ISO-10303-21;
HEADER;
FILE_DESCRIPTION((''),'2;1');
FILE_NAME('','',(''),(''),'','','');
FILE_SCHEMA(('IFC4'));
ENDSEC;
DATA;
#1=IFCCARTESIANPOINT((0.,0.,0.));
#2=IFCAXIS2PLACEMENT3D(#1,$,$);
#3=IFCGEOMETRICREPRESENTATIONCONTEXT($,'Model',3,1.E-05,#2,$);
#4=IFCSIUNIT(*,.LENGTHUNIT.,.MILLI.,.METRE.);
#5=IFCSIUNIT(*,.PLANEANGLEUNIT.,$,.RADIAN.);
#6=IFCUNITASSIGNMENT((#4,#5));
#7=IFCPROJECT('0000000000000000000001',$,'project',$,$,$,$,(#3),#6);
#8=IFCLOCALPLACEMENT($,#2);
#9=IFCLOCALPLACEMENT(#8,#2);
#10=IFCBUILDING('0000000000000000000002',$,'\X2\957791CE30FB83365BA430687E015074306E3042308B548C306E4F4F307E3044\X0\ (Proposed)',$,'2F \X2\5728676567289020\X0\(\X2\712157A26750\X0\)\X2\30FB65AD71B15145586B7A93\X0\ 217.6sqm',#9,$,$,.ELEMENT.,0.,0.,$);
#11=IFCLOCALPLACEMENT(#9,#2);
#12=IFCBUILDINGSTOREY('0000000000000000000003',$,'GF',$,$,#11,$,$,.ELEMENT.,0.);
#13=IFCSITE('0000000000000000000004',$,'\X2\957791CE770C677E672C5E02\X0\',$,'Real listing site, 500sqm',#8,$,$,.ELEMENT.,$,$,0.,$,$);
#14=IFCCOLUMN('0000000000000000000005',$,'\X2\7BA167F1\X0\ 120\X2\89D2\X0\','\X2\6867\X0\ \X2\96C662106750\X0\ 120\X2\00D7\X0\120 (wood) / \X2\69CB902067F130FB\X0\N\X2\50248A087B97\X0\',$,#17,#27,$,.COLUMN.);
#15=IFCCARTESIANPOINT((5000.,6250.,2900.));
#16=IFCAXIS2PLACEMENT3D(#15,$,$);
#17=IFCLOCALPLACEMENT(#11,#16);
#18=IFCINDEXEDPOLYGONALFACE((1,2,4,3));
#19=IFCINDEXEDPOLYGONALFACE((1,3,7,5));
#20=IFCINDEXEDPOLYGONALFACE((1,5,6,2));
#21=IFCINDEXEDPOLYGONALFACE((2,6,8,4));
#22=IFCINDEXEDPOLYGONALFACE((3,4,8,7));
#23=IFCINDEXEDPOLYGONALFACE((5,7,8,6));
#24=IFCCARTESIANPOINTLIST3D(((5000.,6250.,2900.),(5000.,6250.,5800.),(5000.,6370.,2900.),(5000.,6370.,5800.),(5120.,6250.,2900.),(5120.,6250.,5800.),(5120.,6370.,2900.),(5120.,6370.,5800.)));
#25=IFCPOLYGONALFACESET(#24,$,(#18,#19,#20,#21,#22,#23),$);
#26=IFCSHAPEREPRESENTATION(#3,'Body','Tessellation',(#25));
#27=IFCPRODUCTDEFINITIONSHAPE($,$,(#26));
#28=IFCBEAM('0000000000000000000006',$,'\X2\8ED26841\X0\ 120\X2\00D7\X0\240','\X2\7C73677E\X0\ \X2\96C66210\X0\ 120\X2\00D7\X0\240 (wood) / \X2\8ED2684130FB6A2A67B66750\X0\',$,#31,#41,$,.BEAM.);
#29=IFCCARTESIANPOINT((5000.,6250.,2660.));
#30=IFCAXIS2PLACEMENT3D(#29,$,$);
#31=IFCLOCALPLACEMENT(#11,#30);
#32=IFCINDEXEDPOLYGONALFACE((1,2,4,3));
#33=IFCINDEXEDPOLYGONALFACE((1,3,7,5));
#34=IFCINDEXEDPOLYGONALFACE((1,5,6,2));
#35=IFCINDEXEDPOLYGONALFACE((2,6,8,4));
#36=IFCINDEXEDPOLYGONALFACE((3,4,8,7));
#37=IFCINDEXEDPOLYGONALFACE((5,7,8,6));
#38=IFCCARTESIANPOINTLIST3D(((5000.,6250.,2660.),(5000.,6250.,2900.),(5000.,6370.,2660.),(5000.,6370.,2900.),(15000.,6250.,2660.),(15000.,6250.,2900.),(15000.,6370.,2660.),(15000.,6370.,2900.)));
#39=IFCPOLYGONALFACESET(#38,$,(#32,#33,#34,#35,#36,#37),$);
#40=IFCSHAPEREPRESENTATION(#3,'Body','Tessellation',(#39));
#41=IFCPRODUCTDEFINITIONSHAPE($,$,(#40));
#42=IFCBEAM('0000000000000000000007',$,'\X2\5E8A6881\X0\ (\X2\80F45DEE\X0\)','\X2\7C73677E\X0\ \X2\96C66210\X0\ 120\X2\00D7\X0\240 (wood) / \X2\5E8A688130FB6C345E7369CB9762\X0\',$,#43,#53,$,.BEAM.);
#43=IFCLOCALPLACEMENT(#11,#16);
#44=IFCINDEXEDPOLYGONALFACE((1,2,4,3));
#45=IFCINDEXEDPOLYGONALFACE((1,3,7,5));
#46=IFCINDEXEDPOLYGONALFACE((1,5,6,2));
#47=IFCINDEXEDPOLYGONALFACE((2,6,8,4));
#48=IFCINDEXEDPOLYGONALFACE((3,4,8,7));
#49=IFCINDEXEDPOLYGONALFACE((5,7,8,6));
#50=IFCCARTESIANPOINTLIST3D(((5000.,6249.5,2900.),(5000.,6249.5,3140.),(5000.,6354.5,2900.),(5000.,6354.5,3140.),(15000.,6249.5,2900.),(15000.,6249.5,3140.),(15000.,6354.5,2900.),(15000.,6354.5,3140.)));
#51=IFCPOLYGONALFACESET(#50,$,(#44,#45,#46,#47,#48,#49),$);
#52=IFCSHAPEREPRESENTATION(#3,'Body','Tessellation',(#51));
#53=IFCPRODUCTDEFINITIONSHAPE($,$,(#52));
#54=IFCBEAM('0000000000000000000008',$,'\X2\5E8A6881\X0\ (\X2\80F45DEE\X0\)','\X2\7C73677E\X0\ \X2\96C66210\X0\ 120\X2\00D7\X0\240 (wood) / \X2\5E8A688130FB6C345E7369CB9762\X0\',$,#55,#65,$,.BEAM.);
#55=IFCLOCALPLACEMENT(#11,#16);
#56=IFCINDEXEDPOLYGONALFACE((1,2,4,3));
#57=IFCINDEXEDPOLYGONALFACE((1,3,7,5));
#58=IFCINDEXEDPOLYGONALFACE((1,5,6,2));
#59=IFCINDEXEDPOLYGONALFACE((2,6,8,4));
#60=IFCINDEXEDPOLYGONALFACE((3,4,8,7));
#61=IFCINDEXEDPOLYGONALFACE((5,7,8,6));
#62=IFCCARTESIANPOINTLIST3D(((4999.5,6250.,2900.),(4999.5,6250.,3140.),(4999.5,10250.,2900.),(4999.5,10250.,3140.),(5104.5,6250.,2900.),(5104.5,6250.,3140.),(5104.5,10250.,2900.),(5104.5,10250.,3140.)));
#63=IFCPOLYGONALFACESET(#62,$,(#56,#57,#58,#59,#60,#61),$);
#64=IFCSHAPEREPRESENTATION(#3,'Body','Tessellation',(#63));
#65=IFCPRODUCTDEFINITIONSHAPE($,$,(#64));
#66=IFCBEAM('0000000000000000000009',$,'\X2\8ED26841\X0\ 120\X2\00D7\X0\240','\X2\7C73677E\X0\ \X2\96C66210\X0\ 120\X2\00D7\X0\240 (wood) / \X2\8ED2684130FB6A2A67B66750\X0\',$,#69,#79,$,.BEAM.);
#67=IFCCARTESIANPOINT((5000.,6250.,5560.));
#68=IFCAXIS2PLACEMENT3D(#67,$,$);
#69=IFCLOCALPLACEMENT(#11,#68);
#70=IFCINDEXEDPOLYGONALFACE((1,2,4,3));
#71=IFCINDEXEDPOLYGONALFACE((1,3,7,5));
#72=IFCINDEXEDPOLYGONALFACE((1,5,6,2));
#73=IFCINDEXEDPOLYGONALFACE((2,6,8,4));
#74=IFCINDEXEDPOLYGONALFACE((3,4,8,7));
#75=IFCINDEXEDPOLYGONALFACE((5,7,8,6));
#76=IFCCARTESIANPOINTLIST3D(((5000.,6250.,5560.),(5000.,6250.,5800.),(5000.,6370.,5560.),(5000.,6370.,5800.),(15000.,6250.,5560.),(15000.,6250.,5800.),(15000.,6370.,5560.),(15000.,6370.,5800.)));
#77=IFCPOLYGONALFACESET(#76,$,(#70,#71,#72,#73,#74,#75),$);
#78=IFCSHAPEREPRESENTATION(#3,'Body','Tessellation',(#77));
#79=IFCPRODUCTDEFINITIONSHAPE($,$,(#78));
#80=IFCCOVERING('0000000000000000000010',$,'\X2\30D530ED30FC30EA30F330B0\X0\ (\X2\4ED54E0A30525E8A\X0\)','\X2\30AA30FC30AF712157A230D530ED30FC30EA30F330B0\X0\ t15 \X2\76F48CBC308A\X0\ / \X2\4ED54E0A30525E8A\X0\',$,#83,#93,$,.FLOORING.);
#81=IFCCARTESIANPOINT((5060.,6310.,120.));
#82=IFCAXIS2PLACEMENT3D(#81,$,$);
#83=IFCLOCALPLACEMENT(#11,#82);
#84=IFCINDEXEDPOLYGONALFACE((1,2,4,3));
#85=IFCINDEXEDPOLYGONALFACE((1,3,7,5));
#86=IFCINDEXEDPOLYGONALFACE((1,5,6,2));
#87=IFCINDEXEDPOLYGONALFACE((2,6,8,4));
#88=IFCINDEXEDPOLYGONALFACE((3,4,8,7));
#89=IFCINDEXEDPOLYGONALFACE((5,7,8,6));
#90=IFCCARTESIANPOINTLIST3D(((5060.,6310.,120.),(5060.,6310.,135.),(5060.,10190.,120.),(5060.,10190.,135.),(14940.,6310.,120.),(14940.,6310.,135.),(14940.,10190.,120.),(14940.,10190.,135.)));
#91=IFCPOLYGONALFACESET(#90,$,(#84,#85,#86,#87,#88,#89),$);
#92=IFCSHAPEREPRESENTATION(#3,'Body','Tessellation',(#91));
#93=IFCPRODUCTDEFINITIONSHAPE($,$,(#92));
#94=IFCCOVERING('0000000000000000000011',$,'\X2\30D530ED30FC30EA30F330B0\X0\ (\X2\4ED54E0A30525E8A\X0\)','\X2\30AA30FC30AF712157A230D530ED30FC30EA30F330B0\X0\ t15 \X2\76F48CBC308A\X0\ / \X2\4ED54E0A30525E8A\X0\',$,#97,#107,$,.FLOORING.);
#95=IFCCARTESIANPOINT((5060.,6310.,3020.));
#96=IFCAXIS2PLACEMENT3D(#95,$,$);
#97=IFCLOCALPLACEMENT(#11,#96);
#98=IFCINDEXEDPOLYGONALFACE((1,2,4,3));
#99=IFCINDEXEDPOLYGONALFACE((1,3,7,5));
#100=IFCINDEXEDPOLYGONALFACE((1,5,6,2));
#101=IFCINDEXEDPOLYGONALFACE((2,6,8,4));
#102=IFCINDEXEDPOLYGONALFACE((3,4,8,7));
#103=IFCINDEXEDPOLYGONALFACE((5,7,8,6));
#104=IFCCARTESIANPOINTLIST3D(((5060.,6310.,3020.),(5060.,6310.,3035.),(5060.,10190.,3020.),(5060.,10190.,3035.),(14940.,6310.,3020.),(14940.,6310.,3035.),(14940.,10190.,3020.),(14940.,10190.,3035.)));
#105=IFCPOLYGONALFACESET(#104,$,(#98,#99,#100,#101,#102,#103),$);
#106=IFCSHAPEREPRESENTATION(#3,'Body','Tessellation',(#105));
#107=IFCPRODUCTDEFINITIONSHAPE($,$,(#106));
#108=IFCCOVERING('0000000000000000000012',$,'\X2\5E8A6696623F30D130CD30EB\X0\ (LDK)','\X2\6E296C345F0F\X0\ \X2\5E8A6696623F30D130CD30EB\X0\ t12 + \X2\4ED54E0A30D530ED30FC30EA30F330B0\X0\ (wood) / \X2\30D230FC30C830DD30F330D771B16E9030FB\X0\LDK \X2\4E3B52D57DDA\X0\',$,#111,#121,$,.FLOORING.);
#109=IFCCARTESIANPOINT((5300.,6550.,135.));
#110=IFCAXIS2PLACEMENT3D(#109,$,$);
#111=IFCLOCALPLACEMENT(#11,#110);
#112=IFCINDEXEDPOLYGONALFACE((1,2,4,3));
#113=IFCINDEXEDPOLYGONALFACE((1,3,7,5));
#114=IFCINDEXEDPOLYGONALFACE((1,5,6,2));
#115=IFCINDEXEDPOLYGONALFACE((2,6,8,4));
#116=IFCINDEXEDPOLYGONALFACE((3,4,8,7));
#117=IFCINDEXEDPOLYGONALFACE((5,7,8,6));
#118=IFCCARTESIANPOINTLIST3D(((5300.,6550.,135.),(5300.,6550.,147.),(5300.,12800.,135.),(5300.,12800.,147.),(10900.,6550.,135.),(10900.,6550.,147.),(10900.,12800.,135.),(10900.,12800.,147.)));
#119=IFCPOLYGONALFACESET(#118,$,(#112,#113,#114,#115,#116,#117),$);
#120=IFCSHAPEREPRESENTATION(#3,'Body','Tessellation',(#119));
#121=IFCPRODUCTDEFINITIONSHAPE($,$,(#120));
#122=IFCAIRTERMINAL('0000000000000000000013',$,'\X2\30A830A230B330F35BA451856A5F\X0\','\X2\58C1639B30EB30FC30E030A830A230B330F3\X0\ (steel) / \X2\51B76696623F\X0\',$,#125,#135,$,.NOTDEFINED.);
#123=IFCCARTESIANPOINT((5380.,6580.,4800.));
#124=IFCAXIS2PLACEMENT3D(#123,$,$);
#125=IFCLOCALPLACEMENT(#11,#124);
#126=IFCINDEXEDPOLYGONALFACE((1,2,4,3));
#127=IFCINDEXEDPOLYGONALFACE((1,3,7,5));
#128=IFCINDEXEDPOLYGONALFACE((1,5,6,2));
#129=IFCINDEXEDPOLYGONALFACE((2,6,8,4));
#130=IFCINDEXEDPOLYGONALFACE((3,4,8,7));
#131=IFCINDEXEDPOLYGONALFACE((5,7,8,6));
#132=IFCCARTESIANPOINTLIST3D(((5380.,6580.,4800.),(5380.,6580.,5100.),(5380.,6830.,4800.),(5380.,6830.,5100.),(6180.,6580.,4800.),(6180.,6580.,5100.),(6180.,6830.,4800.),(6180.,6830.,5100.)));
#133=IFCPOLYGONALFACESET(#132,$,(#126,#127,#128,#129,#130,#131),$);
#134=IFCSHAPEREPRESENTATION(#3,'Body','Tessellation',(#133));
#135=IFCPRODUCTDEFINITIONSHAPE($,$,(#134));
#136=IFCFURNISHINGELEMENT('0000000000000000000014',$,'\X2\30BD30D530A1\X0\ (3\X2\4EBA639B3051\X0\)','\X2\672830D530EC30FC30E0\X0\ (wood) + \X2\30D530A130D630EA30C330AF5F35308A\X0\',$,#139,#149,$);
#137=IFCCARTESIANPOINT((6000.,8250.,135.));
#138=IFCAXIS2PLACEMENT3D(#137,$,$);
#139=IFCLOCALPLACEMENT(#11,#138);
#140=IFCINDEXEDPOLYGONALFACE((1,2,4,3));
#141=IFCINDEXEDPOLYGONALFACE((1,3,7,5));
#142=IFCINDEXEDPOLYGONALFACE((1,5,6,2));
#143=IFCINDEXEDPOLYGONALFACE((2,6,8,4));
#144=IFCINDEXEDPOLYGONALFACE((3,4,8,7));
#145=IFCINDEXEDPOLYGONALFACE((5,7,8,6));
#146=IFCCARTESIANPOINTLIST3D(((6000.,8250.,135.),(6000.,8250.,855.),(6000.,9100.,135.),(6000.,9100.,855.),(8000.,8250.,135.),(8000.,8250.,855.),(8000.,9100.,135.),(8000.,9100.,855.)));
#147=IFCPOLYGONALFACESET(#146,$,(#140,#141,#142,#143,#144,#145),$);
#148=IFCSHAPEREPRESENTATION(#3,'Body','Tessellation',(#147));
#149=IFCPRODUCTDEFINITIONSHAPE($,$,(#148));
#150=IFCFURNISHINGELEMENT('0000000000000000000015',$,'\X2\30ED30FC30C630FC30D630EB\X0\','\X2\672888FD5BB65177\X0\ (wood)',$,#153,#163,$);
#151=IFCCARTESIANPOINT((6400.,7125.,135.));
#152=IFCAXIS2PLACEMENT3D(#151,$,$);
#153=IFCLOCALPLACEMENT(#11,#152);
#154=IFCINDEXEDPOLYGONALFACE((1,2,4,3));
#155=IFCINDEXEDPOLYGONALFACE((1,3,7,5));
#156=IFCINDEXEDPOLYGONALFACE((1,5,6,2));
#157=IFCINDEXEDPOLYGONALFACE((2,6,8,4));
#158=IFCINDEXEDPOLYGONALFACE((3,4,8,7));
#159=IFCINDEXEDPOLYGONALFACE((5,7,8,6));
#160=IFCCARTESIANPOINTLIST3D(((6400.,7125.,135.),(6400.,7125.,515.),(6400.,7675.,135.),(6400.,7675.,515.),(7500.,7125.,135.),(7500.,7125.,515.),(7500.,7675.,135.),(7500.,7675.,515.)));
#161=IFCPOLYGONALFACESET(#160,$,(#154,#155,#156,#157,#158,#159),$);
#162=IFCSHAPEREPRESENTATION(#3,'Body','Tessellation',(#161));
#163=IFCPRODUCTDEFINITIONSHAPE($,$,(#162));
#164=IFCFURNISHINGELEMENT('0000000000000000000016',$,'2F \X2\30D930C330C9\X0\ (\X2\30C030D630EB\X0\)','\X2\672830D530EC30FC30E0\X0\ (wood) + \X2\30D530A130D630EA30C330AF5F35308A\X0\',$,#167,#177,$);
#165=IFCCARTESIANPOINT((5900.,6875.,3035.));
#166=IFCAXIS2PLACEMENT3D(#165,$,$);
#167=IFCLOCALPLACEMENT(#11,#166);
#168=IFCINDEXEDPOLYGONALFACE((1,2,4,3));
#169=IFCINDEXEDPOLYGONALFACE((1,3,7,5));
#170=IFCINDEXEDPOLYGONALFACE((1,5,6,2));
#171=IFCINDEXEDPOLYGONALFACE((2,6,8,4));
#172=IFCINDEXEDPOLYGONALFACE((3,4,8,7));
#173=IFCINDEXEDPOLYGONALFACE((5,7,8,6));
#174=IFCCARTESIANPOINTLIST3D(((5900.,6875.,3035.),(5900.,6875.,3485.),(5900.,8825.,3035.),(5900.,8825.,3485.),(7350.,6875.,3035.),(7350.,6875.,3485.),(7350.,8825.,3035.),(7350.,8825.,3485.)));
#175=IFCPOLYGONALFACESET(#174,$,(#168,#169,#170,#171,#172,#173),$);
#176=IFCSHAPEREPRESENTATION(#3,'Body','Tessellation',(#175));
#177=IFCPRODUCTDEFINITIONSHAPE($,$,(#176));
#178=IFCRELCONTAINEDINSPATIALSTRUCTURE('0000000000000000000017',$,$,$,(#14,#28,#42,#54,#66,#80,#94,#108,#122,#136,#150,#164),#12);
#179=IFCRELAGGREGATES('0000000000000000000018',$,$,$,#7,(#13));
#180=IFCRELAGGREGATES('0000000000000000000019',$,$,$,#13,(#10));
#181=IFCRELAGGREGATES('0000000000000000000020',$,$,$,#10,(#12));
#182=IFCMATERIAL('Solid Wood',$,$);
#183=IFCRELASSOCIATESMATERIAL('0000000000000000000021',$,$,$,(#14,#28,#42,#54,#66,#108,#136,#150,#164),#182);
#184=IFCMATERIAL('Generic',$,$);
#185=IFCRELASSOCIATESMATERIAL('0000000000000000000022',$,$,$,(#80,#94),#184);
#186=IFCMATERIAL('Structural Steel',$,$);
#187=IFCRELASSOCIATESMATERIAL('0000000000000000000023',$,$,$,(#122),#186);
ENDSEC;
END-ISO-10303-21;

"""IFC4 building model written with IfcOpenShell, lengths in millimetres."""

from ifc_helpers import new_model, si_unit, frame, frame_2d, origin, place, context, project, spatial, rectangle, extrude, material, element, save


model = new_model("IFC4")

# Units and contexts
model_context = context("Model", 3, precision=1e-05, world=origin())
ifc_project = project(units=[si_unit("LENGTHUNIT", "METRE", prefix="MILLI"), si_unit("PLANEANGLEUNIT", "RADIAN")], contexts=[model_context])

# Site, building, storey
site_placement = place(None, origin())
site = spatial("IfcSite", under=ifc_project, at=site_placement, Name="長野県松本市", ObjectType="Real listing site, 500sqm", CompositionType="ELEMENT", RefElevation=0.0)
building_placement = place(site_placement, origin())
building = spatial("IfcBuilding", under=site, at=building_placement, Name="長野・茶室と縁側のある和の住まい (Proposed)", ObjectType="2F 在来木造(無垢材)・断熱充填窓 217.6sqm", CompositionType="ELEMENT", ElevationOfRefHeight=0.0, ElevationOfTerrain=0.0)
storey_placement = place(building_placement, origin())
storey = spatial("IfcBuildingStorey", under=building, at=storey_placement, Name="GF", CompositionType="ELEMENT", Elevation=0.0)

# Column
ifc_material_1 = material(Name="Solid Wood")
column_1_placement = place(storey_placement, frame((5000.0, 6250.0, 2900.0)))
element("IfcColumn", 1, at=column_1_placement, inside=storey, material=ifc_material_1, Name="管柱 120角", Description="桧 集成材 120×120 (wood) / 構造柱・N値計算", PredefinedType="COLUMN", context=model_context, shape_type="SweptSolid", body=[
    extrude(rectangle(XDim=120.0, YDim=120.0, at=frame_2d((60.0, 60.0))), frame((5000.0, 6250.0, 2900.0)), (0.0, 0.0, 1.0), 2900.0),
])

# Beams
beam_1_placement = place(storey_placement, frame((5000.0, 6250.0, 2660.0)))
element("IfcBeam", 2, at=beam_1_placement, inside=storey, material=ifc_material_1, Name="軒桁 120×240", Description="米松 集成 120×240 (wood) / 軒桁・横架材", PredefinedType="BEAM", context=model_context, shape_type="SweptSolid", body=[
    extrude(rectangle(XDim=10000.0, YDim=120.0, at=frame_2d((5000.0, 60.0))), frame((5000.0, 6250.0, 2660.0)), (0.0, 0.0, 1.0), 240.0),
])
beam_2_placement = place(storey_placement, frame((5000.0, 6250.0, 2900.0)))
element("IfcBeam", 3, at=beam_2_placement, inside=storey, material=ifc_material_1, Name="床梁 (胴差)", Description="米松 集成 120×240 (wood) / 床梁・水平構面", PredefinedType="BEAM", context=model_context, shape_type="SweptSolid", body=[
    extrude(rectangle(XDim=10000.0, YDim=105.0, at=frame_2d((5000.0, 52.0))), frame((5000.0, 6250.0, 2900.0)), (0.0, 0.0, 1.0), 240.0),
])
beam_3_placement = place(storey_placement, frame((5000.0, 6250.0, 2900.0)))
element("IfcBeam", 4, at=beam_3_placement, inside=storey, material=ifc_material_1, Name="床梁 (胴差)", Description="米松 集成 120×240 (wood) / 床梁・水平構面", PredefinedType="BEAM", context=model_context, shape_type="SweptSolid", body=[
    extrude(rectangle(XDim=105.0, YDim=4000.0, at=frame_2d((52.0, 2000.0))), frame((5000.0, 6250.0, 2900.0)), (0.0, 0.0, 1.0), 240.0),
])
beam_4_placement = place(storey_placement, frame((5000.0, 6250.0, 5560.0)))
element("IfcBeam", 5, at=beam_4_placement, inside=storey, material=ifc_material_1, Name="軒桁 120×240", Description="米松 集成 120×240 (wood) / 軒桁・横架材", PredefinedType="BEAM", context=model_context, shape_type="SweptSolid", body=[
    extrude(rectangle(XDim=10000.0, YDim=120.0, at=frame_2d((5000.0, 60.0))), frame((5000.0, 6250.0, 5560.0)), (0.0, 0.0, 1.0), 240.0),
])

# Coverings
ifc_material_2 = material(Name="Generic")
covering_1_placement = place(storey_placement, frame((5060.0, 6310.0, 120.0)))
element("IfcCovering", 6, at=covering_1_placement, inside=storey, material=ifc_material_2, Name="フローリング (仕上げ床)", Description="オーク無垢フローリング t15 直貼り / 仕上げ床", PredefinedType="FLOORING", context=model_context, shape_type="SweptSolid", body=[
    extrude(rectangle(XDim=9880.0, YDim=3880.0, at=frame_2d((4940.0, 1940.0))), frame((5060.0, 6310.0, 120.0)), (0.0, 0.0, 1.0), 15.0),
])
covering_2_placement = place(storey_placement, frame((5060.0, 6310.0, 3020.0)))
element("IfcCovering", 7, at=covering_2_placement, inside=storey, material=ifc_material_2, Name="フローリング (仕上げ床)", Description="オーク無垢フローリング t15 直貼り / 仕上げ床", PredefinedType="FLOORING", context=model_context, shape_type="SweptSolid", body=[
    extrude(rectangle(XDim=9880.0, YDim=3880.0, at=frame_2d((4940.0, 1940.0))), frame((5060.0, 6310.0, 3020.0)), (0.0, 0.0, 1.0), 15.0),
])
covering_3_placement = place(storey_placement, frame((5300.0, 6550.0, 135.0)))
element("IfcCovering", 8, at=covering_3_placement, inside=storey, material=ifc_material_1, Name="床暖房パネル (LDK)", Description="温水式 床暖房パネル t12 + 仕上フローリング (wood) / ヒートポンプ熱源・LDK 主動線", PredefinedType="FLOORING", context=model_context, shape_type="SweptSolid", body=[
    extrude(rectangle(XDim=5600.0, YDim=6250.0, at=frame_2d((2800.0, 3125.0))), frame((5300.0, 6550.0, 135.0)), (0.0, 0.0, 1.0), 12.0),
])

# Air terminal
ifc_material_3 = material(Name="Structural Steel")
air_terminal_placement = place(storey_placement, frame((5380.0, 6580.0, 4800.0)))
element("IfcAirTerminal", 9, at=air_terminal_placement, inside=storey, material=ifc_material_3, Name="エアコン室内機", Description="壁掛ルームエアコン (steel) / 冷暖房", PredefinedType="NOTDEFINED", context=model_context, shape_type="SweptSolid", body=[
    extrude(rectangle(XDim=800.0, YDim=250.0, at=frame_2d((400.0, 125.0))), frame((5380.0, 6580.0, 4800.0)), (0.0, 0.0, 1.0), 300.0),
])

# Furnishing elements
furnishing_1_placement = place(storey_placement, frame((6000.0, 8250.0, 135.0)))
element("IfcFurnishingElement", 10, at=furnishing_1_placement, inside=storey, material=ifc_material_1, Name="ソファ (3人掛け)", Description="木フレーム (wood) + ファブリック張り", context=model_context, shape_type="SweptSolid", body=[
    extrude(rectangle(XDim=2000.0, YDim=850.0, at=frame_2d((1000.0, 425.0))), frame((6000.0, 8250.0, 135.0)), (0.0, 0.0, 1.0), 720.0),
])
furnishing_2_placement = place(storey_placement, frame((6400.0, 7125.0, 135.0)))
element("IfcFurnishingElement", 11, at=furnishing_2_placement, inside=storey, material=ifc_material_1, Name="ローテーブル", Description="木製家具 (wood)", context=model_context, shape_type="SweptSolid", body=[
    extrude(rectangle(XDim=1100.0, YDim=550.0, at=frame_2d((550.0, 275.0))), frame((6400.0, 7125.0, 135.0)), (0.0, 0.0, 1.0), 380.0),
])
furnishing_3_placement = place(storey_placement, frame((5900.0, 6875.0, 3035.0)))
element("IfcFurnishingElement", 12, at=furnishing_3_placement, inside=storey, material=ifc_material_1, Name="2F ベッド (ダブル)", Description="木フレーム (wood) + ファブリック張り", context=model_context, shape_type="SweptSolid", body=[
    extrude(rectangle(XDim=1450.0, YDim=1950.0, at=frame_2d((725.0, 975.0))), frame((5900.0, 6875.0, 3035.0)), (0.0, 0.0, 1.0), 450.0),
])

save(model, "model.ifc")
